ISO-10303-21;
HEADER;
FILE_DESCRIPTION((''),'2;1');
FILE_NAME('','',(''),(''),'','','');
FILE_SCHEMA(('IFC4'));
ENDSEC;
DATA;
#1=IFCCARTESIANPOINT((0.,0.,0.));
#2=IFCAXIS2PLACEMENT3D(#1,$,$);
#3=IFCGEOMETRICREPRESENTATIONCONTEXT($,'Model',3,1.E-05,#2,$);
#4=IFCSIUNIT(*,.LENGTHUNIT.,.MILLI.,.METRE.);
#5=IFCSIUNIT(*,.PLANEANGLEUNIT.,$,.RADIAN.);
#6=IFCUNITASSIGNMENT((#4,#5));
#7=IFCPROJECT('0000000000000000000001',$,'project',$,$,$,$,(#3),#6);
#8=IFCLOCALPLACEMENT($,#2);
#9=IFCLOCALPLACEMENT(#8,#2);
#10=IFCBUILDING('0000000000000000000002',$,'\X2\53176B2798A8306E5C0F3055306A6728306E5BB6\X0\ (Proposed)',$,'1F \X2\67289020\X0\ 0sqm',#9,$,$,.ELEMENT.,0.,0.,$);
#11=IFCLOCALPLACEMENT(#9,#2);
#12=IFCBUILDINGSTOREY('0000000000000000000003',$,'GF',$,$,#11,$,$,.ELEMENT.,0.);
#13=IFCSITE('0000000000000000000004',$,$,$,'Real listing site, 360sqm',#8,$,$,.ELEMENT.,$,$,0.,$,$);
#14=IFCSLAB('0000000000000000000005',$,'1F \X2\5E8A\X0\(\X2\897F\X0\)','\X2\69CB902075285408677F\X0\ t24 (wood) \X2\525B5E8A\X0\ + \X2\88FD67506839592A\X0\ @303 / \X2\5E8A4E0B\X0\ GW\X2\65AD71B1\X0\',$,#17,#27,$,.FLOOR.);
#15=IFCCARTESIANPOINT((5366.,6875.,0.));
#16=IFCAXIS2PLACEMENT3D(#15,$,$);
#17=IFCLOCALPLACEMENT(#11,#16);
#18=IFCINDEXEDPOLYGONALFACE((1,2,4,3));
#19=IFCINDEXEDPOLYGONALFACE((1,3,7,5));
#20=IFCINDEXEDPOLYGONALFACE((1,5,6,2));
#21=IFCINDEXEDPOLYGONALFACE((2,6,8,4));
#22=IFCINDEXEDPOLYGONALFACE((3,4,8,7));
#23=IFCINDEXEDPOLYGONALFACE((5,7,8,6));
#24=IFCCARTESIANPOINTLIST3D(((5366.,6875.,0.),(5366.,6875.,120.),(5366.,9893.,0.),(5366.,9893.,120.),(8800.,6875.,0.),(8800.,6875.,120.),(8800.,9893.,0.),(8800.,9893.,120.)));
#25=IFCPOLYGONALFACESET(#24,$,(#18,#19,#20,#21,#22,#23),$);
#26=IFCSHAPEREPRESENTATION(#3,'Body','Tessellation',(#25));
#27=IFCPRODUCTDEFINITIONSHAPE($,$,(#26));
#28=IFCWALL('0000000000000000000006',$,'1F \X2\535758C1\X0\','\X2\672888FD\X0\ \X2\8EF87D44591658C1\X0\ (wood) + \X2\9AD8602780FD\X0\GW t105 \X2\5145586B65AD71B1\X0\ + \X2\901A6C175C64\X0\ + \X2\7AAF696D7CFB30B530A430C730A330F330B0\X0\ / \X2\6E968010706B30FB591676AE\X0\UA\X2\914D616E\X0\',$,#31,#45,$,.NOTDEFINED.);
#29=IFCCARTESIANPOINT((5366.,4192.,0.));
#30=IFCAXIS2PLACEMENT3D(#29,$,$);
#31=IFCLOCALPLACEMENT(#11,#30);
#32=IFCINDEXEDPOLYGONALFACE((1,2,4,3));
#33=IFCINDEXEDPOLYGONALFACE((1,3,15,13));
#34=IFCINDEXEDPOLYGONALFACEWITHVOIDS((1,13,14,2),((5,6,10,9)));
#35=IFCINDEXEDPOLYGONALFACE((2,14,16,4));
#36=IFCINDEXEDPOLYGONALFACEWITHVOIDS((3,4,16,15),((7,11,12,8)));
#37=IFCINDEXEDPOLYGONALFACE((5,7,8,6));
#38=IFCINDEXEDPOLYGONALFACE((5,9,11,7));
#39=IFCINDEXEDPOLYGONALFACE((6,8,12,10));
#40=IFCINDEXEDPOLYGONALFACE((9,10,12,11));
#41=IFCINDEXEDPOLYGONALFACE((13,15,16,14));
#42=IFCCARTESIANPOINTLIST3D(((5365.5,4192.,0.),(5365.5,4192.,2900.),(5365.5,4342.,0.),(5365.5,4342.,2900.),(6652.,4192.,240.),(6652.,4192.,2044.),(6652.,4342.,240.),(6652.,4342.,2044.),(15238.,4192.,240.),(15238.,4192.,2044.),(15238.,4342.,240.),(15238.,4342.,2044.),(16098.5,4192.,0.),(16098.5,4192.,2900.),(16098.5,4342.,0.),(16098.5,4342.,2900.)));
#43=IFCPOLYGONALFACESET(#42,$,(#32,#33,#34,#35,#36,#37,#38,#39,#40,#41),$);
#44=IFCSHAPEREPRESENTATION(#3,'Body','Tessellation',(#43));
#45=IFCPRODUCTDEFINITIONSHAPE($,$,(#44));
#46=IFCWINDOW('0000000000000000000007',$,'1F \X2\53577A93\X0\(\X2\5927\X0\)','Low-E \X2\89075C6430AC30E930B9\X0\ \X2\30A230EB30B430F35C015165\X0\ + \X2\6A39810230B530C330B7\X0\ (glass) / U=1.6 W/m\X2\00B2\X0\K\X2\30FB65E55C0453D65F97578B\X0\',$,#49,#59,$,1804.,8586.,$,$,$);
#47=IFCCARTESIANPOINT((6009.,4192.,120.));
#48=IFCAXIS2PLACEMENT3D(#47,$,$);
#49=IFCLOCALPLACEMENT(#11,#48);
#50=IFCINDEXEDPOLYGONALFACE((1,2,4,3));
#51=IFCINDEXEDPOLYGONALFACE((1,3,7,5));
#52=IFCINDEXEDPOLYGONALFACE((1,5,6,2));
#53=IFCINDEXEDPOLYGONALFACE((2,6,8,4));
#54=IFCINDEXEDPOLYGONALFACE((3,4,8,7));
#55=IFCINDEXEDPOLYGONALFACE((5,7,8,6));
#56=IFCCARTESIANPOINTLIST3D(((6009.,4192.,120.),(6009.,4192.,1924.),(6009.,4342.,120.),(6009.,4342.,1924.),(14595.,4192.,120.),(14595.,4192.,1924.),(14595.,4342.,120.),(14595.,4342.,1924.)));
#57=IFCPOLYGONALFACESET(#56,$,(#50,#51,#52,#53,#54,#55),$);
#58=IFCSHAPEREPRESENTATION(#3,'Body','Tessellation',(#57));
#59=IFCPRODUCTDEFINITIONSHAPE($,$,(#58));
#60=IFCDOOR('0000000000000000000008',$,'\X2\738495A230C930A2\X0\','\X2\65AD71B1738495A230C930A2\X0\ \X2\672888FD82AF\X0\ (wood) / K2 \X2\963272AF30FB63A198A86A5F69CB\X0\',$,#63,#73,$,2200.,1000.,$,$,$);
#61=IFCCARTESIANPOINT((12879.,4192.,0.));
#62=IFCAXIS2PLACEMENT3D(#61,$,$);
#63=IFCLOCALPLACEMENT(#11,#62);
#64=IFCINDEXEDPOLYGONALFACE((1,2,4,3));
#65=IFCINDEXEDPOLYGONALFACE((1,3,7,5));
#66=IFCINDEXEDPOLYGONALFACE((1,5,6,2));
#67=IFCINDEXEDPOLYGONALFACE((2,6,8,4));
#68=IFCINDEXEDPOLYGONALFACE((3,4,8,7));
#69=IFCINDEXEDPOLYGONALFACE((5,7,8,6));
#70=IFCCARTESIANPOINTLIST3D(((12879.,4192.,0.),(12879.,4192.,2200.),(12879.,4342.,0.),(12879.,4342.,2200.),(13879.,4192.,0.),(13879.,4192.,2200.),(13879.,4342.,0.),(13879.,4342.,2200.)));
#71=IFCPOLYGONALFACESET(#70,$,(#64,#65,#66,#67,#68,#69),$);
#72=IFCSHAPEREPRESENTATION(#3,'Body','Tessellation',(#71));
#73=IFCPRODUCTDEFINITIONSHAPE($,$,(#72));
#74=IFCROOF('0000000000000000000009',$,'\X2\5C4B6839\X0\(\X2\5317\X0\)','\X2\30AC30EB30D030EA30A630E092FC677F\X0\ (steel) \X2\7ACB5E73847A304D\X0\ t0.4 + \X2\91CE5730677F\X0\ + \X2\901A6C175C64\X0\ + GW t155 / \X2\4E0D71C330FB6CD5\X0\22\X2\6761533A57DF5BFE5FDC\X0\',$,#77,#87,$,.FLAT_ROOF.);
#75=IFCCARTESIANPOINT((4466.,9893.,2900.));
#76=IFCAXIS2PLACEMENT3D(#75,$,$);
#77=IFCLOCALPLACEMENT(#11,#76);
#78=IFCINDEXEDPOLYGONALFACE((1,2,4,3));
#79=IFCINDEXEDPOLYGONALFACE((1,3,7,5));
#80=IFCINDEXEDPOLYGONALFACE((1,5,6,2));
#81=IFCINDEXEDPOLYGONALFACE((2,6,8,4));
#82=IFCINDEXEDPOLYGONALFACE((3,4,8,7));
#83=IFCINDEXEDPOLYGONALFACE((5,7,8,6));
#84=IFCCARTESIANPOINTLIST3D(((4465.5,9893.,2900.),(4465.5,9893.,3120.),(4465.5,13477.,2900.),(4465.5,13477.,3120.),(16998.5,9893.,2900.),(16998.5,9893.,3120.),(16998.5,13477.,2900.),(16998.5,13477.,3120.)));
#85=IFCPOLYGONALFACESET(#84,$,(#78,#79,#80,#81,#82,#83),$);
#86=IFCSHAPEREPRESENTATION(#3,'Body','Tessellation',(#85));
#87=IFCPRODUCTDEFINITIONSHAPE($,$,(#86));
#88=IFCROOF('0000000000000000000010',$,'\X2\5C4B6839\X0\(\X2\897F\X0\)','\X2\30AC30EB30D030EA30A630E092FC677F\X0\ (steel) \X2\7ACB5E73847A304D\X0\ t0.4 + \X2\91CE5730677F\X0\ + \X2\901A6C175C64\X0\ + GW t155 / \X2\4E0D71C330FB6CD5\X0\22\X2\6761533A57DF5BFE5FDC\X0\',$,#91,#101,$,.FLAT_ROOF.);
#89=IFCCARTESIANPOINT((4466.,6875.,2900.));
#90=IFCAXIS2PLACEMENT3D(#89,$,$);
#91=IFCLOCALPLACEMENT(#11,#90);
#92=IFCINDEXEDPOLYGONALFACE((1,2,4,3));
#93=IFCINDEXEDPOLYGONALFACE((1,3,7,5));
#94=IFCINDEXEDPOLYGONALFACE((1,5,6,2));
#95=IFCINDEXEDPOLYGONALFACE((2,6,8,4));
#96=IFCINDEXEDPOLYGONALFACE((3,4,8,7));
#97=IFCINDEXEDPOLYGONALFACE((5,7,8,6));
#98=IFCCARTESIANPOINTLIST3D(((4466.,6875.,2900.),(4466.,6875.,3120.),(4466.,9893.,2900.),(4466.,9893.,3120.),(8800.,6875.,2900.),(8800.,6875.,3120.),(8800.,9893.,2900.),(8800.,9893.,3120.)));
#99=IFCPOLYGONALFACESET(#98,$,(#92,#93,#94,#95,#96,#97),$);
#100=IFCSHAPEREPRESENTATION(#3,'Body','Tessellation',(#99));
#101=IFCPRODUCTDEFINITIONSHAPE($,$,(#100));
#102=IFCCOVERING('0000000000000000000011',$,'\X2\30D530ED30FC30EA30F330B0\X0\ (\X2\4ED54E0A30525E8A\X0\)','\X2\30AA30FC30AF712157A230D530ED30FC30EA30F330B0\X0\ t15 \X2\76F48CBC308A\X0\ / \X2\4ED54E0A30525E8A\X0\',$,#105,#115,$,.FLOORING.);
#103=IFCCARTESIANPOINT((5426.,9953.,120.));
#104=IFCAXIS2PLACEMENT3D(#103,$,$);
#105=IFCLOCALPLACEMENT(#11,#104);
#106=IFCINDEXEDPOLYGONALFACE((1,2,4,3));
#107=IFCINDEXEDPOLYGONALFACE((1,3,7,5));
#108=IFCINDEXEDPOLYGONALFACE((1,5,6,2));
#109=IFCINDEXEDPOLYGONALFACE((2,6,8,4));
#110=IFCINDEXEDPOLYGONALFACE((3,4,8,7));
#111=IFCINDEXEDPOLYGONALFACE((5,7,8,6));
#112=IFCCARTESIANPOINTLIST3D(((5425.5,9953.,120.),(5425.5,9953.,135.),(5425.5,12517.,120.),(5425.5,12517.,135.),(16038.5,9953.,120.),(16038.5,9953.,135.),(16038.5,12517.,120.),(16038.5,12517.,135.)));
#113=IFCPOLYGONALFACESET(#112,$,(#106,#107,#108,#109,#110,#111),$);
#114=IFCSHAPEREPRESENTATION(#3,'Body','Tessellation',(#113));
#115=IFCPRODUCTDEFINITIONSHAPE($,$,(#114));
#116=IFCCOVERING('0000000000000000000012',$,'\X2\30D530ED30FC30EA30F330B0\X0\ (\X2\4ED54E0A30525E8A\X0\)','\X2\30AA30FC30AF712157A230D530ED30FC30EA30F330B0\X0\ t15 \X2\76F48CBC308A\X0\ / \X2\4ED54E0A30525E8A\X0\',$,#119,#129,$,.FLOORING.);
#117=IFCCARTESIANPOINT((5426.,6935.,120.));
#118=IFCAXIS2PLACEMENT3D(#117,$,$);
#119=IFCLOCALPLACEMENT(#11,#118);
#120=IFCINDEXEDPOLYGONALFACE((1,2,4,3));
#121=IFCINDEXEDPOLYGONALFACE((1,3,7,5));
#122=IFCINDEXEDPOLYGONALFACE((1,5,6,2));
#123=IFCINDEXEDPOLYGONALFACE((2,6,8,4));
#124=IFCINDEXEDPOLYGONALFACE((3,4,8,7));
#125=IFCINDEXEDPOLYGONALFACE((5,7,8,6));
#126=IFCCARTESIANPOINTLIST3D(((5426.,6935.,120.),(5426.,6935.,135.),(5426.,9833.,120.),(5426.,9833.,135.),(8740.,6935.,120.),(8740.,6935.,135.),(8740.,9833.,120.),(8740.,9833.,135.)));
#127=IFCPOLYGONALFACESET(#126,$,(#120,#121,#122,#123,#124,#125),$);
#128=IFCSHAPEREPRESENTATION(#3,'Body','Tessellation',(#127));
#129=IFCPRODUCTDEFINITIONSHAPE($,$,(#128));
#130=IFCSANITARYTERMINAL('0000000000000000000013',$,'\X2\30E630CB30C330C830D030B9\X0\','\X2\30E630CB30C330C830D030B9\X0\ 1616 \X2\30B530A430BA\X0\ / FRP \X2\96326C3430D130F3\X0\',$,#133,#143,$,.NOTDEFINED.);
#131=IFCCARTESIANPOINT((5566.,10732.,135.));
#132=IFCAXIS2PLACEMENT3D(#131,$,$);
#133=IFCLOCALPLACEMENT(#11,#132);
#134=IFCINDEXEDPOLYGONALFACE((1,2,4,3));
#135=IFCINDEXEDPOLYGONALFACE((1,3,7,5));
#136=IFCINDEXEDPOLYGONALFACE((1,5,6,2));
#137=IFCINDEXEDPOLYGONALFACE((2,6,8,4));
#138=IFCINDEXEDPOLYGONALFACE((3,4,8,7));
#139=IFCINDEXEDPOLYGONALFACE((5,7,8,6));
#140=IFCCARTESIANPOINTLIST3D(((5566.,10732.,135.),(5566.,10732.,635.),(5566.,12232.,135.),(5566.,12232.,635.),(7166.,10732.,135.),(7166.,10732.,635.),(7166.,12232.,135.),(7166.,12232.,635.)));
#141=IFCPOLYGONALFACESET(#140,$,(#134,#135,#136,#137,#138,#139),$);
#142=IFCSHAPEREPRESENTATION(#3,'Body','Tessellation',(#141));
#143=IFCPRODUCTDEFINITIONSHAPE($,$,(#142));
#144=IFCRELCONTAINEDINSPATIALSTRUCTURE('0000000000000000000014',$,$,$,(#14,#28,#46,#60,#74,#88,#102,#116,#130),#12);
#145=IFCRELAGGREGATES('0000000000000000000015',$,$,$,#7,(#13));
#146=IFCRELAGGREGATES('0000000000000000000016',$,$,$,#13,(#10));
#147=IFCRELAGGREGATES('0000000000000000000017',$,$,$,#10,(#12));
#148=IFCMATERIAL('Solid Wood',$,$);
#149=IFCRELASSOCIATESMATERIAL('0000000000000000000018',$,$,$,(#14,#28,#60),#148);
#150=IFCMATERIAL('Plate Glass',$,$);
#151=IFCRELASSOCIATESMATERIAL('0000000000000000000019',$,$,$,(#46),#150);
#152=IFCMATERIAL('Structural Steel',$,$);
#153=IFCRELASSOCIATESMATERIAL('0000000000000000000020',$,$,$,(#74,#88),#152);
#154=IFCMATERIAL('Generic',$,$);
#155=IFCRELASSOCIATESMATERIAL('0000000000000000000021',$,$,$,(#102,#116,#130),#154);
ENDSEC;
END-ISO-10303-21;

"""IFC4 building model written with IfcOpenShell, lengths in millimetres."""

from ifc_helpers import new_model, si_unit, frame, frame_2d, origin, place, context, project, spatial, rectangle, extrude, material, element, fill, save


model = new_model("IFC4")

# Units and contexts
model_context = context("Model", 3, precision=1e-05, world=origin())
ifc_project = project(units=[si_unit("LENGTHUNIT", "METRE", prefix="MILLI"), si_unit("PLANEANGLEUNIT", "RADIAN")], contexts=[model_context])

# Site, building, storey
site_placement = place(None, origin())
site = spatial("IfcSite", under=ifc_project, at=site_placement, ObjectType="Real listing site, 360sqm", CompositionType="ELEMENT", RefElevation=0.0)
building_placement = place(site_placement, origin())
building = spatial("IfcBuilding", under=site, at=building_placement, Name="北欧風の小さな木の家 (Proposed)", ObjectType="1F 木造 0sqm", CompositionType="ELEMENT", ElevationOfRefHeight=0.0, ElevationOfTerrain=0.0)
storey_placement = place(building_placement, origin())
storey = spatial("IfcBuildingStorey", under=building, at=storey_placement, Name="GF", CompositionType="ELEMENT", Elevation=0.0)

# Slab
ifc_material_1 = material(Name="Solid Wood")
slab_1_placement = place(storey_placement, frame((5366.0, 6875.0, 0.0)))
element("IfcSlab", 1, at=slab_1_placement, inside=storey, material=ifc_material_1, Name="1F 床(西)", Description="構造用合板 t24 (wood) 剛床 + 製材根太 @303 / 床下 GW断熱", PredefinedType="FLOOR", context=model_context, shape_type="SweptSolid", body=[
    extrude(rectangle(XDim=3434.0, YDim=3018.0, at=frame_2d((1717.0, 1509.0))), frame((5366.0, 6875.0, 0.0)), (0.0, 0.0, 1.0), 120.0),
])

# Wall, openings, window, door
wall_1_placement = place(storey_placement, frame((5366.0, 4192.0, 0.0)))
wall_1 = element("IfcWall", 2, at=wall_1_placement, inside=storey, material=ifc_material_1, Name="1F 南壁", Description="木製 軸組外壁 (wood) + 高性能GW t105 充填断熱 + 通気層 + 窯業系サイディング / 準耐火・外皮UA配慮", PredefinedType="NOTDEFINED", context=model_context, shape_type="SweptSolid", body=[
    extrude(rectangle(XDim=10733.0, YDim=150.0, at=frame_2d((5366.0, 75.0))), frame((5366.0, 4192.0, 0.0)), (0.0, 0.0, 1.0), 2900.0),
])
opening_1_placement = place(storey_placement, frame((6009.0, 4192.0, 120.0)))
opening_1 = element("IfcOpeningElement", 3, at=opening_1_placement, cuts=wall_1, PredefinedType="NOTDEFINED", context=model_context, shape_type="SweptSolid", body=[
    extrude(rectangle(XDim=8586.0, YDim=150.0, at=frame_2d((4293.0, 75.0))), frame((6009.0, 4192.0, 120.0)), (0.0, 0.0, 1.0), 1804.0),
])
opening_2_placement = place(storey_placement, frame((12879.0, 4192.0, 0.0)))
opening_2 = element("IfcOpeningElement", 4, at=opening_2_placement, cuts=wall_1, PredefinedType="NOTDEFINED", context=model_context, shape_type="SweptSolid", body=[
    extrude(rectangle(XDim=1000.0, YDim=150.0, at=frame_2d((500.0, 75.0))), frame((12879.0, 4192.0, 0.0)), (0.0, 0.0, 1.0), 2200.0),
])
ifc_material_2 = material(Name="Plate Glass")
window_1_placement = place(storey_placement, frame((6009.0, 4192.0, 120.0)))
window_1 = element("IfcWindow", 5, at=window_1_placement, inside=storey, material=ifc_material_2, Name="1F 南窓(大)", Description="Low-E 複層ガラス アルゴン封入 + 樹脂サッシ (glass) / U=1.6 W/m²K・日射取得型", OverallHeight=1804.0, OverallWidth=8586.0, context=model_context, shape_type="SweptSolid", body=[
    extrude(rectangle(XDim=8586.0, YDim=150.0, at=frame_2d((4293.0, 75.0))), frame((6009.0, 4192.0, 120.0)), (0.0, 0.0, 1.0), 1804.0),
])
fill(opening_1, window_1)
door_placement = place(storey_placement, frame((12879.0, 4192.0, 0.0)))
door = element("IfcDoor", 6, at=door_placement, inside=storey, material=ifc_material_1, Name="玄関ドア", Description="断熱玄関ドア 木製芯 (wood) / K2 防犯・採風機構", OverallHeight=2200.0, OverallWidth=1000.0, context=model_context, shape_type="SweptSolid", body=[
    extrude(rectangle(XDim=1000.0, YDim=150.0, at=frame_2d((500.0, 75.0))), frame((12879.0, 4192.0, 0.0)), (0.0, 0.0, 1.0), 2200.0),
])
fill(opening_2, door)

# Roofs
ifc_material_3 = material(Name="Structural Steel")
roof_1_placement = place(storey_placement, frame((4466.0, 9893.0, 2900.0)))
element("IfcRoof", 7, at=roof_1_placement, inside=storey, material=ifc_material_3, Name="屋根(北)", Description="ガルバリウム鋼板 (steel) 立平葺き t0.4 + 野地板 + 通気層 + GW t155 / 不燃・法22条区域対応", PredefinedType="FLAT_ROOF", context=model_context, shape_type="SweptSolid", body=[
    extrude(rectangle(XDim=12533.0, YDim=3584.0, at=frame_2d((6266.0, 1792.0))), frame((4466.0, 9893.0, 2900.0)), (0.0, 0.0, 1.0), 220.0),
])
roof_2_placement = place(storey_placement, frame((4466.0, 6875.0, 2900.0)))
element("IfcRoof", 8, at=roof_2_placement, inside=storey, material=ifc_material_3, Name="屋根(西)", Description="ガルバリウム鋼板 (steel) 立平葺き t0.4 + 野地板 + 通気層 + GW t155 / 不燃・法22条区域対応", PredefinedType="FLAT_ROOF", context=model_context, shape_type="SweptSolid", body=[
    extrude(rectangle(XDim=4334.0, YDim=3018.0, at=frame_2d((2167.0, 1509.0))), frame((4466.0, 6875.0, 2900.0)), (0.0, 0.0, 1.0), 220.0),
])

# Coverings
ifc_material_4 = material(Name="Generic")
covering_1_placement = place(storey_placement, frame((5426.0, 9953.0, 120.0)))
element("IfcCovering", 9, at=covering_1_placement, inside=storey, material=ifc_material_4, Name="フローリング (仕上げ床)", Description="オーク無垢フローリング t15 直貼り / 仕上げ床", PredefinedType="FLOORING", context=model_context, shape_type="SweptSolid", body=[
    extrude(rectangle(XDim=10613.0, YDim=2564.0, at=frame_2d((5306.0, 1282.0))), frame((5426.0, 9953.0, 120.0)), (0.0, 0.0, 1.0), 15.0),
])
covering_2_placement = place(storey_placement, frame((5426.0, 6935.0, 120.0)))
element("IfcCovering", 10, at=covering_2_placement, inside=storey, material=ifc_material_4, Name="フローリング (仕上げ床)", Description="オーク無垢フローリング t15 直貼り / 仕上げ床", PredefinedType="FLOORING", context=model_context, shape_type="SweptSolid", body=[
    extrude(rectangle(XDim=3314.0, YDim=2898.0, at=frame_2d((1657.0, 1449.0))), frame((5426.0, 6935.0, 120.0)), (0.0, 0.0, 1.0), 15.0),
])

# Sanitary terminal
sanitary_terminal_placement = place(storey_placement, frame((5566.0, 10732.0, 135.0)))
element("IfcSanitaryTerminal", 11, at=sanitary_terminal_placement, inside=storey, material=ifc_material_4, Name="ユニットバス", Description="ユニットバス 1616 サイズ / FRP 防水パン", PredefinedType="NOTDEFINED", context=model_context, shape_type="SweptSolid", body=[
    extrude(rectangle(XDim=1600.0, YDim=1500.0, at=frame_2d((800.0, 750.0))), frame((5566.0, 10732.0, 135.0)), (0.0, 0.0, 1.0), 500.0),
])

save(model, "model.ifc")
